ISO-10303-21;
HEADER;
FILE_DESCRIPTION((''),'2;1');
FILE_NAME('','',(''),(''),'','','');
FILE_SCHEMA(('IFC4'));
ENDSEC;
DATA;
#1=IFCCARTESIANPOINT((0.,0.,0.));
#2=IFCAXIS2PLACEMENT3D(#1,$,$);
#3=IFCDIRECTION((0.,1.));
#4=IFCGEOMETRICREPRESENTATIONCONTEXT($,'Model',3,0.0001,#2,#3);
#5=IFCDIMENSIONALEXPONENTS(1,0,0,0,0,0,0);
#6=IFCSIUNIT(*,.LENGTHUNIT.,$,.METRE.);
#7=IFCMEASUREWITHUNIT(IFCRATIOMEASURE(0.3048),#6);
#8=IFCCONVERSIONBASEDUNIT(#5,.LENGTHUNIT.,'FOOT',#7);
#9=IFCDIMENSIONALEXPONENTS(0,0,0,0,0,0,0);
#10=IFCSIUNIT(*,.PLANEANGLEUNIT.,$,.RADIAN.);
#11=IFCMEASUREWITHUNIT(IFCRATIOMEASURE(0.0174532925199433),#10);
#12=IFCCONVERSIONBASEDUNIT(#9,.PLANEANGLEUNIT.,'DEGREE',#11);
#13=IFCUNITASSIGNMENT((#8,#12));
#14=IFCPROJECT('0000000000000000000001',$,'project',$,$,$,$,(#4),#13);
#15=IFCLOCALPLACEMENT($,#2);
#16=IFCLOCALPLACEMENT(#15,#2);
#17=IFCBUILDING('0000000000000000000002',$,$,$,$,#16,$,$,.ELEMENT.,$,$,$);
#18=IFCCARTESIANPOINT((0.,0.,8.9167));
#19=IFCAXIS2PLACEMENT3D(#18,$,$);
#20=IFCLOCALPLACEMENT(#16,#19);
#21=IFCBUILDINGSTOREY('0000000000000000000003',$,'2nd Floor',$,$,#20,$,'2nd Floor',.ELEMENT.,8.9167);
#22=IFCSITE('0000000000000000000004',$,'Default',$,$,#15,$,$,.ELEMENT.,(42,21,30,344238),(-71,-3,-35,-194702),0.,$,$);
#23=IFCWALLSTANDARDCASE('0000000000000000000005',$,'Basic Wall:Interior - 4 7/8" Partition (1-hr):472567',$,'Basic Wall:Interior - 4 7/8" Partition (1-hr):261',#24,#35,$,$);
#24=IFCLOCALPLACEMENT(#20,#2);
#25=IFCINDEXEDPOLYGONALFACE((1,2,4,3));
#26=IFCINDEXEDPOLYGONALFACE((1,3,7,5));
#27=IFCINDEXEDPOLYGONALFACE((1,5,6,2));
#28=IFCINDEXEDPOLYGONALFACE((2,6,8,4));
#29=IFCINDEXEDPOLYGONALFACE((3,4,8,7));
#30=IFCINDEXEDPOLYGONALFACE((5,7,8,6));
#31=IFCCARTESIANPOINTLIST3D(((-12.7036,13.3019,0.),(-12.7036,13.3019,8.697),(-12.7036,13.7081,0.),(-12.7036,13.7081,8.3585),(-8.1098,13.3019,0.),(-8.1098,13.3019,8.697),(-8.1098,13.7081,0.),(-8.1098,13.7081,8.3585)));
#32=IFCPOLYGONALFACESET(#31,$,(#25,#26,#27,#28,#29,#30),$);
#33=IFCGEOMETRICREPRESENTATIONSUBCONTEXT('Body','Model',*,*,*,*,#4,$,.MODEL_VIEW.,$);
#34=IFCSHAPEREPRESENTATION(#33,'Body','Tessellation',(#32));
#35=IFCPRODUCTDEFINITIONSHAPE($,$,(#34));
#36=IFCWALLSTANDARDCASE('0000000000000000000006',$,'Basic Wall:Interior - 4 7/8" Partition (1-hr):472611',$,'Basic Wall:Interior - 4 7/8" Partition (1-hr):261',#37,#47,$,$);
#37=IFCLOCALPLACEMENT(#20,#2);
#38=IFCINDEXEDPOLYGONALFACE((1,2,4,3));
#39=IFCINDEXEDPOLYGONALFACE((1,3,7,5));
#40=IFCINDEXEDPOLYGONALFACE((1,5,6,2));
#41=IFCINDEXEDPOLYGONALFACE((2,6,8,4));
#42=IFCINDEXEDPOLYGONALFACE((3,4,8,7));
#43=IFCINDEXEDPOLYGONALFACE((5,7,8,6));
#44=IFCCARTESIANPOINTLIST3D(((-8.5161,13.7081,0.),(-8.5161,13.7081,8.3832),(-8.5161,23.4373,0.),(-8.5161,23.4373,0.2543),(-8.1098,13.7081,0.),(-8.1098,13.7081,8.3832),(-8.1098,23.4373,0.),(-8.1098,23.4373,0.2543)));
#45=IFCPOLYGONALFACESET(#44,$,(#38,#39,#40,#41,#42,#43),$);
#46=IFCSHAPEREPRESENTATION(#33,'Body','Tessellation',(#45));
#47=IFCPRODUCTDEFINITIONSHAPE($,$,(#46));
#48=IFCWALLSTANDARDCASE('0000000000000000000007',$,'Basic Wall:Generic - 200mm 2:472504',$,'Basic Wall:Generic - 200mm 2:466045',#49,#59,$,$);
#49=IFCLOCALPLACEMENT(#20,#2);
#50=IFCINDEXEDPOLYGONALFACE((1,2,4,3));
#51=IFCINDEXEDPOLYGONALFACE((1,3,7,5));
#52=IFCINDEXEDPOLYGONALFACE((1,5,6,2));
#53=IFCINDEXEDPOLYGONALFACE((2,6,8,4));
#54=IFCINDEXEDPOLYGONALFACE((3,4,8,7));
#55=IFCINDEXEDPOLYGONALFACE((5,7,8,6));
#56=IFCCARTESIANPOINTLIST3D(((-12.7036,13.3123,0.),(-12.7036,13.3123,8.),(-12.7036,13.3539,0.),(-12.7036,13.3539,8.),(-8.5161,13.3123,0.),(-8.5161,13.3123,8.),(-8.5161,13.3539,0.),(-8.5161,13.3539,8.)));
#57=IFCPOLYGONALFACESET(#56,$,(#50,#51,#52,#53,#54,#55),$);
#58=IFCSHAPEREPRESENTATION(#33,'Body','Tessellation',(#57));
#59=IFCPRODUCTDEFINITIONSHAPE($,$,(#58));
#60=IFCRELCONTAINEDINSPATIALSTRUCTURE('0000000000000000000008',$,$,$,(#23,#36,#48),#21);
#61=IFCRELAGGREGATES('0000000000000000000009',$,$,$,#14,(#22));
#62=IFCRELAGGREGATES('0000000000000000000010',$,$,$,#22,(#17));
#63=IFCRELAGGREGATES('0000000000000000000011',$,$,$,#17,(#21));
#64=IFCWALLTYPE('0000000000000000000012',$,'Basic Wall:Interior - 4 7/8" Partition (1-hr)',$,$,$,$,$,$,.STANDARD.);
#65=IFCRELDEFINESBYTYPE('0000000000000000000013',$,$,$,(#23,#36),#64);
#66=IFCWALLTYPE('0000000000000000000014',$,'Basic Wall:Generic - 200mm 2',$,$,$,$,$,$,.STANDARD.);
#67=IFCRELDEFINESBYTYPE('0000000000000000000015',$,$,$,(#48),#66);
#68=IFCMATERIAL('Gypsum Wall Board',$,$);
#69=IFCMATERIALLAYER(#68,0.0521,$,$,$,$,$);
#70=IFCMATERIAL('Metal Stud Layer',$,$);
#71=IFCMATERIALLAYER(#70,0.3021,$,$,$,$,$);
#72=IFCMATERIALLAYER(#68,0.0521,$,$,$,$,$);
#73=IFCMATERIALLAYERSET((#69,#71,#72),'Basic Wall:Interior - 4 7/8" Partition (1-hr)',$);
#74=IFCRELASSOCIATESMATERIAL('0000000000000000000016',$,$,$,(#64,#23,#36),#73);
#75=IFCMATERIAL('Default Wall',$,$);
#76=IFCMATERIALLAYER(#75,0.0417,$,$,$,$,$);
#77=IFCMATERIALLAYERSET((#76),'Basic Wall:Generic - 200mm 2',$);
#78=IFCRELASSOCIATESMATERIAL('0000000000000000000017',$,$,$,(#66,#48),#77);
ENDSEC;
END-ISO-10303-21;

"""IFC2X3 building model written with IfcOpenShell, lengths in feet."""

from ifc_helpers import new_model, entity, si_unit, converted_unit, direction, frame, frame_2d, origin, place, context, subcontext, project, spatial, polyline, rectangle, extrude, clip, bounded_halfspace, material, layer, layer_set, layer_usage, type_object, element, save


model = new_model("IFC2X3")

# Units and contexts
model_context = context("Model", 3, precision=0.0001, world=origin(), true_north=direction((0.0, 1.0)))
body_context = subcontext(model_context, "Body", "Model", "MODEL_VIEW")
ifc_project = project(units=[converted_unit("LENGTHUNIT", "FOOT", entity("IfcRatioMeasure", 0.3048), si_unit("LENGTHUNIT", "METRE"), dimensions=[1, 0, 0, 0, 0, 0, 0]), converted_unit("PLANEANGLEUNIT", "DEGREE", entity("IfcRatioMeasure", 0.0174532925199433), si_unit("PLANEANGLEUNIT", "RADIAN"), dimensions=[0, 0, 0, 0, 0, 0, 0])], contexts=[model_context])

# Site, building, storey
site_placement = place(None, origin())
site = spatial("IfcSite", under=ifc_project, at=site_placement, Name="Default", CompositionType="ELEMENT", RefLatitude=(42, 21, 30, 344238), RefLongitude=(-71, -3, -35, -194702), RefElevation=0.0)
building_placement = place(site_placement, origin())
building = spatial("IfcBuilding", under=site, at=building_placement, CompositionType="ELEMENT")
storey_placement = place(building_placement, frame((0.0, 0.0, 8.9167)))
storey = spatial("IfcBuildingStorey", under=building, at=storey_placement, Name="2nd Floor", LongName="2nd Floor", CompositionType="ELEMENT", Elevation=8.9167)

# Shared definitions
ifc_material_1 = material(Name="Gypsum Wall Board")

# Walls
ifc_layer_1 = layer(ifc_material_1, 0.0521)
ifc_material_2 = material(Name="Metal Stud Layer")
ifc_layer_2 = layer(ifc_material_2, 0.3021)
ifc_layer_3 = layer(ifc_material_1, 0.0521)
ifc_layer_set_1 = layer_set([ifc_layer_1, ifc_layer_2, ifc_layer_3], Name="Basic Wall:Interior - 4 7/8\" Partition (1-hr)")
ifc_layer_usage_1 = layer_usage(ifc_layer_set_1, "AXIS2", "NEGATIVE", 0.2031)
wall_type_1 = type_object("IfcWallType", Name="Basic Wall:Interior - 4 7/8\" Partition (1-hr)", PredefinedType="STANDARD", material=ifc_layer_set_1)
wall_1_placement = place(storey_placement, frame((-12.7036, 13.505, 0.0)))
element("IfcWallStandardCase", 1, at=wall_1_placement, inside=storey, type_object=wall_type_1, material=ifc_layer_usage_1, Name="Basic Wall:Interior - 4 7/8\" Partition (1-hr):472567", ObjectType="Basic Wall:Interior - 4 7/8\" Partition (1-hr):261", context=body_context, shape_type="Clipping", body=[
    clip(extrude(rectangle(XDim=4.5937, YDim=0.4062, at=frame_2d((2.2969, 0.0), x_axis=(-1.0, 0.0))), origin(), (0.0, 0.0, 1.0), 8.697), bounded_halfspace(frame((0.0, -0.2031, 8.697), z_axis=(0.0, 0.640184, 0.768221), x_axis=(-1.0, 0.0, 0.0)), False, frame((0.0, -0.2031, 8.697)), polyline([(0.0, 0.0), (4.5937, 0.0), (4.5937, 0.4063), (0.0, 0.4062), (0.0, 0.0)]))),
])
ifc_layer_usage_2 = layer_usage(ifc_layer_set_1, "AXIS2", "NEGATIVE", 0.2031)
wall_2_placement = place(storey_placement, frame((-8.3129, 13.7081, 0.0), z_axis=(0.0, 0.0, 1.0), x_axis=(0.0, 1.0, 0.0)))
element("IfcWallStandardCase", 2, at=wall_2_placement, inside=storey, type_object=wall_type_1, material=ifc_layer_usage_2, Name="Basic Wall:Interior - 4 7/8\" Partition (1-hr):472611", ObjectType="Basic Wall:Interior - 4 7/8\" Partition (1-hr):261", context=body_context, shape_type="Clipping", body=[
    clip(extrude(rectangle(XDim=9.7291, YDim=0.4062, at=frame_2d((4.8646, 0.0), x_axis=(-1.0, 0.0))), origin(), (0.0, 0.0, 1.0), 8.3832), bounded_halfspace(frame((0.0, -0.2031, 8.3832), z_axis=(0.641172, 0.0, 0.767397), x_axis=(0.0, 1.0, 0.0)), False, frame((0.0, -0.2031, 8.3832)), polyline([(0.0, 0.0), (9.7291, 0.0), (9.7291, 0.4062), (0.0, 0.4062), (0.0, 0.0)]))),
])
ifc_material_3 = material(Name="Default Wall")
ifc_layer_4 = layer(ifc_material_3, 0.0417)
ifc_layer_set_2 = layer_set([ifc_layer_4], Name="Basic Wall:Generic - 200mm 2")
ifc_layer_usage_3 = layer_usage(ifc_layer_set_2, "AXIS2", "NEGATIVE", 0.0208)
wall_type_2 = type_object("IfcWallType", Name="Basic Wall:Generic - 200mm 2", PredefinedType="STANDARD", material=ifc_layer_set_2)
wall_3_placement = place(storey_placement, frame((-12.7036, 13.3331, 0.0)))
element("IfcWallStandardCase", 3, at=wall_3_placement, inside=storey, type_object=wall_type_2, material=ifc_layer_usage_3, Name="Basic Wall:Generic - 200mm 2:472504", ObjectType="Basic Wall:Generic - 200mm 2:466045", context=body_context, shape_type="SweptSolid", body=[
    extrude(rectangle(XDim=4.1875, YDim=0.0417, at=frame_2d((2.0937, 0.0), x_axis=(-1.0, 0.0))), origin(), (0.0, 0.0, 1.0), 8.0),
])

save(model, "model.ifc")
